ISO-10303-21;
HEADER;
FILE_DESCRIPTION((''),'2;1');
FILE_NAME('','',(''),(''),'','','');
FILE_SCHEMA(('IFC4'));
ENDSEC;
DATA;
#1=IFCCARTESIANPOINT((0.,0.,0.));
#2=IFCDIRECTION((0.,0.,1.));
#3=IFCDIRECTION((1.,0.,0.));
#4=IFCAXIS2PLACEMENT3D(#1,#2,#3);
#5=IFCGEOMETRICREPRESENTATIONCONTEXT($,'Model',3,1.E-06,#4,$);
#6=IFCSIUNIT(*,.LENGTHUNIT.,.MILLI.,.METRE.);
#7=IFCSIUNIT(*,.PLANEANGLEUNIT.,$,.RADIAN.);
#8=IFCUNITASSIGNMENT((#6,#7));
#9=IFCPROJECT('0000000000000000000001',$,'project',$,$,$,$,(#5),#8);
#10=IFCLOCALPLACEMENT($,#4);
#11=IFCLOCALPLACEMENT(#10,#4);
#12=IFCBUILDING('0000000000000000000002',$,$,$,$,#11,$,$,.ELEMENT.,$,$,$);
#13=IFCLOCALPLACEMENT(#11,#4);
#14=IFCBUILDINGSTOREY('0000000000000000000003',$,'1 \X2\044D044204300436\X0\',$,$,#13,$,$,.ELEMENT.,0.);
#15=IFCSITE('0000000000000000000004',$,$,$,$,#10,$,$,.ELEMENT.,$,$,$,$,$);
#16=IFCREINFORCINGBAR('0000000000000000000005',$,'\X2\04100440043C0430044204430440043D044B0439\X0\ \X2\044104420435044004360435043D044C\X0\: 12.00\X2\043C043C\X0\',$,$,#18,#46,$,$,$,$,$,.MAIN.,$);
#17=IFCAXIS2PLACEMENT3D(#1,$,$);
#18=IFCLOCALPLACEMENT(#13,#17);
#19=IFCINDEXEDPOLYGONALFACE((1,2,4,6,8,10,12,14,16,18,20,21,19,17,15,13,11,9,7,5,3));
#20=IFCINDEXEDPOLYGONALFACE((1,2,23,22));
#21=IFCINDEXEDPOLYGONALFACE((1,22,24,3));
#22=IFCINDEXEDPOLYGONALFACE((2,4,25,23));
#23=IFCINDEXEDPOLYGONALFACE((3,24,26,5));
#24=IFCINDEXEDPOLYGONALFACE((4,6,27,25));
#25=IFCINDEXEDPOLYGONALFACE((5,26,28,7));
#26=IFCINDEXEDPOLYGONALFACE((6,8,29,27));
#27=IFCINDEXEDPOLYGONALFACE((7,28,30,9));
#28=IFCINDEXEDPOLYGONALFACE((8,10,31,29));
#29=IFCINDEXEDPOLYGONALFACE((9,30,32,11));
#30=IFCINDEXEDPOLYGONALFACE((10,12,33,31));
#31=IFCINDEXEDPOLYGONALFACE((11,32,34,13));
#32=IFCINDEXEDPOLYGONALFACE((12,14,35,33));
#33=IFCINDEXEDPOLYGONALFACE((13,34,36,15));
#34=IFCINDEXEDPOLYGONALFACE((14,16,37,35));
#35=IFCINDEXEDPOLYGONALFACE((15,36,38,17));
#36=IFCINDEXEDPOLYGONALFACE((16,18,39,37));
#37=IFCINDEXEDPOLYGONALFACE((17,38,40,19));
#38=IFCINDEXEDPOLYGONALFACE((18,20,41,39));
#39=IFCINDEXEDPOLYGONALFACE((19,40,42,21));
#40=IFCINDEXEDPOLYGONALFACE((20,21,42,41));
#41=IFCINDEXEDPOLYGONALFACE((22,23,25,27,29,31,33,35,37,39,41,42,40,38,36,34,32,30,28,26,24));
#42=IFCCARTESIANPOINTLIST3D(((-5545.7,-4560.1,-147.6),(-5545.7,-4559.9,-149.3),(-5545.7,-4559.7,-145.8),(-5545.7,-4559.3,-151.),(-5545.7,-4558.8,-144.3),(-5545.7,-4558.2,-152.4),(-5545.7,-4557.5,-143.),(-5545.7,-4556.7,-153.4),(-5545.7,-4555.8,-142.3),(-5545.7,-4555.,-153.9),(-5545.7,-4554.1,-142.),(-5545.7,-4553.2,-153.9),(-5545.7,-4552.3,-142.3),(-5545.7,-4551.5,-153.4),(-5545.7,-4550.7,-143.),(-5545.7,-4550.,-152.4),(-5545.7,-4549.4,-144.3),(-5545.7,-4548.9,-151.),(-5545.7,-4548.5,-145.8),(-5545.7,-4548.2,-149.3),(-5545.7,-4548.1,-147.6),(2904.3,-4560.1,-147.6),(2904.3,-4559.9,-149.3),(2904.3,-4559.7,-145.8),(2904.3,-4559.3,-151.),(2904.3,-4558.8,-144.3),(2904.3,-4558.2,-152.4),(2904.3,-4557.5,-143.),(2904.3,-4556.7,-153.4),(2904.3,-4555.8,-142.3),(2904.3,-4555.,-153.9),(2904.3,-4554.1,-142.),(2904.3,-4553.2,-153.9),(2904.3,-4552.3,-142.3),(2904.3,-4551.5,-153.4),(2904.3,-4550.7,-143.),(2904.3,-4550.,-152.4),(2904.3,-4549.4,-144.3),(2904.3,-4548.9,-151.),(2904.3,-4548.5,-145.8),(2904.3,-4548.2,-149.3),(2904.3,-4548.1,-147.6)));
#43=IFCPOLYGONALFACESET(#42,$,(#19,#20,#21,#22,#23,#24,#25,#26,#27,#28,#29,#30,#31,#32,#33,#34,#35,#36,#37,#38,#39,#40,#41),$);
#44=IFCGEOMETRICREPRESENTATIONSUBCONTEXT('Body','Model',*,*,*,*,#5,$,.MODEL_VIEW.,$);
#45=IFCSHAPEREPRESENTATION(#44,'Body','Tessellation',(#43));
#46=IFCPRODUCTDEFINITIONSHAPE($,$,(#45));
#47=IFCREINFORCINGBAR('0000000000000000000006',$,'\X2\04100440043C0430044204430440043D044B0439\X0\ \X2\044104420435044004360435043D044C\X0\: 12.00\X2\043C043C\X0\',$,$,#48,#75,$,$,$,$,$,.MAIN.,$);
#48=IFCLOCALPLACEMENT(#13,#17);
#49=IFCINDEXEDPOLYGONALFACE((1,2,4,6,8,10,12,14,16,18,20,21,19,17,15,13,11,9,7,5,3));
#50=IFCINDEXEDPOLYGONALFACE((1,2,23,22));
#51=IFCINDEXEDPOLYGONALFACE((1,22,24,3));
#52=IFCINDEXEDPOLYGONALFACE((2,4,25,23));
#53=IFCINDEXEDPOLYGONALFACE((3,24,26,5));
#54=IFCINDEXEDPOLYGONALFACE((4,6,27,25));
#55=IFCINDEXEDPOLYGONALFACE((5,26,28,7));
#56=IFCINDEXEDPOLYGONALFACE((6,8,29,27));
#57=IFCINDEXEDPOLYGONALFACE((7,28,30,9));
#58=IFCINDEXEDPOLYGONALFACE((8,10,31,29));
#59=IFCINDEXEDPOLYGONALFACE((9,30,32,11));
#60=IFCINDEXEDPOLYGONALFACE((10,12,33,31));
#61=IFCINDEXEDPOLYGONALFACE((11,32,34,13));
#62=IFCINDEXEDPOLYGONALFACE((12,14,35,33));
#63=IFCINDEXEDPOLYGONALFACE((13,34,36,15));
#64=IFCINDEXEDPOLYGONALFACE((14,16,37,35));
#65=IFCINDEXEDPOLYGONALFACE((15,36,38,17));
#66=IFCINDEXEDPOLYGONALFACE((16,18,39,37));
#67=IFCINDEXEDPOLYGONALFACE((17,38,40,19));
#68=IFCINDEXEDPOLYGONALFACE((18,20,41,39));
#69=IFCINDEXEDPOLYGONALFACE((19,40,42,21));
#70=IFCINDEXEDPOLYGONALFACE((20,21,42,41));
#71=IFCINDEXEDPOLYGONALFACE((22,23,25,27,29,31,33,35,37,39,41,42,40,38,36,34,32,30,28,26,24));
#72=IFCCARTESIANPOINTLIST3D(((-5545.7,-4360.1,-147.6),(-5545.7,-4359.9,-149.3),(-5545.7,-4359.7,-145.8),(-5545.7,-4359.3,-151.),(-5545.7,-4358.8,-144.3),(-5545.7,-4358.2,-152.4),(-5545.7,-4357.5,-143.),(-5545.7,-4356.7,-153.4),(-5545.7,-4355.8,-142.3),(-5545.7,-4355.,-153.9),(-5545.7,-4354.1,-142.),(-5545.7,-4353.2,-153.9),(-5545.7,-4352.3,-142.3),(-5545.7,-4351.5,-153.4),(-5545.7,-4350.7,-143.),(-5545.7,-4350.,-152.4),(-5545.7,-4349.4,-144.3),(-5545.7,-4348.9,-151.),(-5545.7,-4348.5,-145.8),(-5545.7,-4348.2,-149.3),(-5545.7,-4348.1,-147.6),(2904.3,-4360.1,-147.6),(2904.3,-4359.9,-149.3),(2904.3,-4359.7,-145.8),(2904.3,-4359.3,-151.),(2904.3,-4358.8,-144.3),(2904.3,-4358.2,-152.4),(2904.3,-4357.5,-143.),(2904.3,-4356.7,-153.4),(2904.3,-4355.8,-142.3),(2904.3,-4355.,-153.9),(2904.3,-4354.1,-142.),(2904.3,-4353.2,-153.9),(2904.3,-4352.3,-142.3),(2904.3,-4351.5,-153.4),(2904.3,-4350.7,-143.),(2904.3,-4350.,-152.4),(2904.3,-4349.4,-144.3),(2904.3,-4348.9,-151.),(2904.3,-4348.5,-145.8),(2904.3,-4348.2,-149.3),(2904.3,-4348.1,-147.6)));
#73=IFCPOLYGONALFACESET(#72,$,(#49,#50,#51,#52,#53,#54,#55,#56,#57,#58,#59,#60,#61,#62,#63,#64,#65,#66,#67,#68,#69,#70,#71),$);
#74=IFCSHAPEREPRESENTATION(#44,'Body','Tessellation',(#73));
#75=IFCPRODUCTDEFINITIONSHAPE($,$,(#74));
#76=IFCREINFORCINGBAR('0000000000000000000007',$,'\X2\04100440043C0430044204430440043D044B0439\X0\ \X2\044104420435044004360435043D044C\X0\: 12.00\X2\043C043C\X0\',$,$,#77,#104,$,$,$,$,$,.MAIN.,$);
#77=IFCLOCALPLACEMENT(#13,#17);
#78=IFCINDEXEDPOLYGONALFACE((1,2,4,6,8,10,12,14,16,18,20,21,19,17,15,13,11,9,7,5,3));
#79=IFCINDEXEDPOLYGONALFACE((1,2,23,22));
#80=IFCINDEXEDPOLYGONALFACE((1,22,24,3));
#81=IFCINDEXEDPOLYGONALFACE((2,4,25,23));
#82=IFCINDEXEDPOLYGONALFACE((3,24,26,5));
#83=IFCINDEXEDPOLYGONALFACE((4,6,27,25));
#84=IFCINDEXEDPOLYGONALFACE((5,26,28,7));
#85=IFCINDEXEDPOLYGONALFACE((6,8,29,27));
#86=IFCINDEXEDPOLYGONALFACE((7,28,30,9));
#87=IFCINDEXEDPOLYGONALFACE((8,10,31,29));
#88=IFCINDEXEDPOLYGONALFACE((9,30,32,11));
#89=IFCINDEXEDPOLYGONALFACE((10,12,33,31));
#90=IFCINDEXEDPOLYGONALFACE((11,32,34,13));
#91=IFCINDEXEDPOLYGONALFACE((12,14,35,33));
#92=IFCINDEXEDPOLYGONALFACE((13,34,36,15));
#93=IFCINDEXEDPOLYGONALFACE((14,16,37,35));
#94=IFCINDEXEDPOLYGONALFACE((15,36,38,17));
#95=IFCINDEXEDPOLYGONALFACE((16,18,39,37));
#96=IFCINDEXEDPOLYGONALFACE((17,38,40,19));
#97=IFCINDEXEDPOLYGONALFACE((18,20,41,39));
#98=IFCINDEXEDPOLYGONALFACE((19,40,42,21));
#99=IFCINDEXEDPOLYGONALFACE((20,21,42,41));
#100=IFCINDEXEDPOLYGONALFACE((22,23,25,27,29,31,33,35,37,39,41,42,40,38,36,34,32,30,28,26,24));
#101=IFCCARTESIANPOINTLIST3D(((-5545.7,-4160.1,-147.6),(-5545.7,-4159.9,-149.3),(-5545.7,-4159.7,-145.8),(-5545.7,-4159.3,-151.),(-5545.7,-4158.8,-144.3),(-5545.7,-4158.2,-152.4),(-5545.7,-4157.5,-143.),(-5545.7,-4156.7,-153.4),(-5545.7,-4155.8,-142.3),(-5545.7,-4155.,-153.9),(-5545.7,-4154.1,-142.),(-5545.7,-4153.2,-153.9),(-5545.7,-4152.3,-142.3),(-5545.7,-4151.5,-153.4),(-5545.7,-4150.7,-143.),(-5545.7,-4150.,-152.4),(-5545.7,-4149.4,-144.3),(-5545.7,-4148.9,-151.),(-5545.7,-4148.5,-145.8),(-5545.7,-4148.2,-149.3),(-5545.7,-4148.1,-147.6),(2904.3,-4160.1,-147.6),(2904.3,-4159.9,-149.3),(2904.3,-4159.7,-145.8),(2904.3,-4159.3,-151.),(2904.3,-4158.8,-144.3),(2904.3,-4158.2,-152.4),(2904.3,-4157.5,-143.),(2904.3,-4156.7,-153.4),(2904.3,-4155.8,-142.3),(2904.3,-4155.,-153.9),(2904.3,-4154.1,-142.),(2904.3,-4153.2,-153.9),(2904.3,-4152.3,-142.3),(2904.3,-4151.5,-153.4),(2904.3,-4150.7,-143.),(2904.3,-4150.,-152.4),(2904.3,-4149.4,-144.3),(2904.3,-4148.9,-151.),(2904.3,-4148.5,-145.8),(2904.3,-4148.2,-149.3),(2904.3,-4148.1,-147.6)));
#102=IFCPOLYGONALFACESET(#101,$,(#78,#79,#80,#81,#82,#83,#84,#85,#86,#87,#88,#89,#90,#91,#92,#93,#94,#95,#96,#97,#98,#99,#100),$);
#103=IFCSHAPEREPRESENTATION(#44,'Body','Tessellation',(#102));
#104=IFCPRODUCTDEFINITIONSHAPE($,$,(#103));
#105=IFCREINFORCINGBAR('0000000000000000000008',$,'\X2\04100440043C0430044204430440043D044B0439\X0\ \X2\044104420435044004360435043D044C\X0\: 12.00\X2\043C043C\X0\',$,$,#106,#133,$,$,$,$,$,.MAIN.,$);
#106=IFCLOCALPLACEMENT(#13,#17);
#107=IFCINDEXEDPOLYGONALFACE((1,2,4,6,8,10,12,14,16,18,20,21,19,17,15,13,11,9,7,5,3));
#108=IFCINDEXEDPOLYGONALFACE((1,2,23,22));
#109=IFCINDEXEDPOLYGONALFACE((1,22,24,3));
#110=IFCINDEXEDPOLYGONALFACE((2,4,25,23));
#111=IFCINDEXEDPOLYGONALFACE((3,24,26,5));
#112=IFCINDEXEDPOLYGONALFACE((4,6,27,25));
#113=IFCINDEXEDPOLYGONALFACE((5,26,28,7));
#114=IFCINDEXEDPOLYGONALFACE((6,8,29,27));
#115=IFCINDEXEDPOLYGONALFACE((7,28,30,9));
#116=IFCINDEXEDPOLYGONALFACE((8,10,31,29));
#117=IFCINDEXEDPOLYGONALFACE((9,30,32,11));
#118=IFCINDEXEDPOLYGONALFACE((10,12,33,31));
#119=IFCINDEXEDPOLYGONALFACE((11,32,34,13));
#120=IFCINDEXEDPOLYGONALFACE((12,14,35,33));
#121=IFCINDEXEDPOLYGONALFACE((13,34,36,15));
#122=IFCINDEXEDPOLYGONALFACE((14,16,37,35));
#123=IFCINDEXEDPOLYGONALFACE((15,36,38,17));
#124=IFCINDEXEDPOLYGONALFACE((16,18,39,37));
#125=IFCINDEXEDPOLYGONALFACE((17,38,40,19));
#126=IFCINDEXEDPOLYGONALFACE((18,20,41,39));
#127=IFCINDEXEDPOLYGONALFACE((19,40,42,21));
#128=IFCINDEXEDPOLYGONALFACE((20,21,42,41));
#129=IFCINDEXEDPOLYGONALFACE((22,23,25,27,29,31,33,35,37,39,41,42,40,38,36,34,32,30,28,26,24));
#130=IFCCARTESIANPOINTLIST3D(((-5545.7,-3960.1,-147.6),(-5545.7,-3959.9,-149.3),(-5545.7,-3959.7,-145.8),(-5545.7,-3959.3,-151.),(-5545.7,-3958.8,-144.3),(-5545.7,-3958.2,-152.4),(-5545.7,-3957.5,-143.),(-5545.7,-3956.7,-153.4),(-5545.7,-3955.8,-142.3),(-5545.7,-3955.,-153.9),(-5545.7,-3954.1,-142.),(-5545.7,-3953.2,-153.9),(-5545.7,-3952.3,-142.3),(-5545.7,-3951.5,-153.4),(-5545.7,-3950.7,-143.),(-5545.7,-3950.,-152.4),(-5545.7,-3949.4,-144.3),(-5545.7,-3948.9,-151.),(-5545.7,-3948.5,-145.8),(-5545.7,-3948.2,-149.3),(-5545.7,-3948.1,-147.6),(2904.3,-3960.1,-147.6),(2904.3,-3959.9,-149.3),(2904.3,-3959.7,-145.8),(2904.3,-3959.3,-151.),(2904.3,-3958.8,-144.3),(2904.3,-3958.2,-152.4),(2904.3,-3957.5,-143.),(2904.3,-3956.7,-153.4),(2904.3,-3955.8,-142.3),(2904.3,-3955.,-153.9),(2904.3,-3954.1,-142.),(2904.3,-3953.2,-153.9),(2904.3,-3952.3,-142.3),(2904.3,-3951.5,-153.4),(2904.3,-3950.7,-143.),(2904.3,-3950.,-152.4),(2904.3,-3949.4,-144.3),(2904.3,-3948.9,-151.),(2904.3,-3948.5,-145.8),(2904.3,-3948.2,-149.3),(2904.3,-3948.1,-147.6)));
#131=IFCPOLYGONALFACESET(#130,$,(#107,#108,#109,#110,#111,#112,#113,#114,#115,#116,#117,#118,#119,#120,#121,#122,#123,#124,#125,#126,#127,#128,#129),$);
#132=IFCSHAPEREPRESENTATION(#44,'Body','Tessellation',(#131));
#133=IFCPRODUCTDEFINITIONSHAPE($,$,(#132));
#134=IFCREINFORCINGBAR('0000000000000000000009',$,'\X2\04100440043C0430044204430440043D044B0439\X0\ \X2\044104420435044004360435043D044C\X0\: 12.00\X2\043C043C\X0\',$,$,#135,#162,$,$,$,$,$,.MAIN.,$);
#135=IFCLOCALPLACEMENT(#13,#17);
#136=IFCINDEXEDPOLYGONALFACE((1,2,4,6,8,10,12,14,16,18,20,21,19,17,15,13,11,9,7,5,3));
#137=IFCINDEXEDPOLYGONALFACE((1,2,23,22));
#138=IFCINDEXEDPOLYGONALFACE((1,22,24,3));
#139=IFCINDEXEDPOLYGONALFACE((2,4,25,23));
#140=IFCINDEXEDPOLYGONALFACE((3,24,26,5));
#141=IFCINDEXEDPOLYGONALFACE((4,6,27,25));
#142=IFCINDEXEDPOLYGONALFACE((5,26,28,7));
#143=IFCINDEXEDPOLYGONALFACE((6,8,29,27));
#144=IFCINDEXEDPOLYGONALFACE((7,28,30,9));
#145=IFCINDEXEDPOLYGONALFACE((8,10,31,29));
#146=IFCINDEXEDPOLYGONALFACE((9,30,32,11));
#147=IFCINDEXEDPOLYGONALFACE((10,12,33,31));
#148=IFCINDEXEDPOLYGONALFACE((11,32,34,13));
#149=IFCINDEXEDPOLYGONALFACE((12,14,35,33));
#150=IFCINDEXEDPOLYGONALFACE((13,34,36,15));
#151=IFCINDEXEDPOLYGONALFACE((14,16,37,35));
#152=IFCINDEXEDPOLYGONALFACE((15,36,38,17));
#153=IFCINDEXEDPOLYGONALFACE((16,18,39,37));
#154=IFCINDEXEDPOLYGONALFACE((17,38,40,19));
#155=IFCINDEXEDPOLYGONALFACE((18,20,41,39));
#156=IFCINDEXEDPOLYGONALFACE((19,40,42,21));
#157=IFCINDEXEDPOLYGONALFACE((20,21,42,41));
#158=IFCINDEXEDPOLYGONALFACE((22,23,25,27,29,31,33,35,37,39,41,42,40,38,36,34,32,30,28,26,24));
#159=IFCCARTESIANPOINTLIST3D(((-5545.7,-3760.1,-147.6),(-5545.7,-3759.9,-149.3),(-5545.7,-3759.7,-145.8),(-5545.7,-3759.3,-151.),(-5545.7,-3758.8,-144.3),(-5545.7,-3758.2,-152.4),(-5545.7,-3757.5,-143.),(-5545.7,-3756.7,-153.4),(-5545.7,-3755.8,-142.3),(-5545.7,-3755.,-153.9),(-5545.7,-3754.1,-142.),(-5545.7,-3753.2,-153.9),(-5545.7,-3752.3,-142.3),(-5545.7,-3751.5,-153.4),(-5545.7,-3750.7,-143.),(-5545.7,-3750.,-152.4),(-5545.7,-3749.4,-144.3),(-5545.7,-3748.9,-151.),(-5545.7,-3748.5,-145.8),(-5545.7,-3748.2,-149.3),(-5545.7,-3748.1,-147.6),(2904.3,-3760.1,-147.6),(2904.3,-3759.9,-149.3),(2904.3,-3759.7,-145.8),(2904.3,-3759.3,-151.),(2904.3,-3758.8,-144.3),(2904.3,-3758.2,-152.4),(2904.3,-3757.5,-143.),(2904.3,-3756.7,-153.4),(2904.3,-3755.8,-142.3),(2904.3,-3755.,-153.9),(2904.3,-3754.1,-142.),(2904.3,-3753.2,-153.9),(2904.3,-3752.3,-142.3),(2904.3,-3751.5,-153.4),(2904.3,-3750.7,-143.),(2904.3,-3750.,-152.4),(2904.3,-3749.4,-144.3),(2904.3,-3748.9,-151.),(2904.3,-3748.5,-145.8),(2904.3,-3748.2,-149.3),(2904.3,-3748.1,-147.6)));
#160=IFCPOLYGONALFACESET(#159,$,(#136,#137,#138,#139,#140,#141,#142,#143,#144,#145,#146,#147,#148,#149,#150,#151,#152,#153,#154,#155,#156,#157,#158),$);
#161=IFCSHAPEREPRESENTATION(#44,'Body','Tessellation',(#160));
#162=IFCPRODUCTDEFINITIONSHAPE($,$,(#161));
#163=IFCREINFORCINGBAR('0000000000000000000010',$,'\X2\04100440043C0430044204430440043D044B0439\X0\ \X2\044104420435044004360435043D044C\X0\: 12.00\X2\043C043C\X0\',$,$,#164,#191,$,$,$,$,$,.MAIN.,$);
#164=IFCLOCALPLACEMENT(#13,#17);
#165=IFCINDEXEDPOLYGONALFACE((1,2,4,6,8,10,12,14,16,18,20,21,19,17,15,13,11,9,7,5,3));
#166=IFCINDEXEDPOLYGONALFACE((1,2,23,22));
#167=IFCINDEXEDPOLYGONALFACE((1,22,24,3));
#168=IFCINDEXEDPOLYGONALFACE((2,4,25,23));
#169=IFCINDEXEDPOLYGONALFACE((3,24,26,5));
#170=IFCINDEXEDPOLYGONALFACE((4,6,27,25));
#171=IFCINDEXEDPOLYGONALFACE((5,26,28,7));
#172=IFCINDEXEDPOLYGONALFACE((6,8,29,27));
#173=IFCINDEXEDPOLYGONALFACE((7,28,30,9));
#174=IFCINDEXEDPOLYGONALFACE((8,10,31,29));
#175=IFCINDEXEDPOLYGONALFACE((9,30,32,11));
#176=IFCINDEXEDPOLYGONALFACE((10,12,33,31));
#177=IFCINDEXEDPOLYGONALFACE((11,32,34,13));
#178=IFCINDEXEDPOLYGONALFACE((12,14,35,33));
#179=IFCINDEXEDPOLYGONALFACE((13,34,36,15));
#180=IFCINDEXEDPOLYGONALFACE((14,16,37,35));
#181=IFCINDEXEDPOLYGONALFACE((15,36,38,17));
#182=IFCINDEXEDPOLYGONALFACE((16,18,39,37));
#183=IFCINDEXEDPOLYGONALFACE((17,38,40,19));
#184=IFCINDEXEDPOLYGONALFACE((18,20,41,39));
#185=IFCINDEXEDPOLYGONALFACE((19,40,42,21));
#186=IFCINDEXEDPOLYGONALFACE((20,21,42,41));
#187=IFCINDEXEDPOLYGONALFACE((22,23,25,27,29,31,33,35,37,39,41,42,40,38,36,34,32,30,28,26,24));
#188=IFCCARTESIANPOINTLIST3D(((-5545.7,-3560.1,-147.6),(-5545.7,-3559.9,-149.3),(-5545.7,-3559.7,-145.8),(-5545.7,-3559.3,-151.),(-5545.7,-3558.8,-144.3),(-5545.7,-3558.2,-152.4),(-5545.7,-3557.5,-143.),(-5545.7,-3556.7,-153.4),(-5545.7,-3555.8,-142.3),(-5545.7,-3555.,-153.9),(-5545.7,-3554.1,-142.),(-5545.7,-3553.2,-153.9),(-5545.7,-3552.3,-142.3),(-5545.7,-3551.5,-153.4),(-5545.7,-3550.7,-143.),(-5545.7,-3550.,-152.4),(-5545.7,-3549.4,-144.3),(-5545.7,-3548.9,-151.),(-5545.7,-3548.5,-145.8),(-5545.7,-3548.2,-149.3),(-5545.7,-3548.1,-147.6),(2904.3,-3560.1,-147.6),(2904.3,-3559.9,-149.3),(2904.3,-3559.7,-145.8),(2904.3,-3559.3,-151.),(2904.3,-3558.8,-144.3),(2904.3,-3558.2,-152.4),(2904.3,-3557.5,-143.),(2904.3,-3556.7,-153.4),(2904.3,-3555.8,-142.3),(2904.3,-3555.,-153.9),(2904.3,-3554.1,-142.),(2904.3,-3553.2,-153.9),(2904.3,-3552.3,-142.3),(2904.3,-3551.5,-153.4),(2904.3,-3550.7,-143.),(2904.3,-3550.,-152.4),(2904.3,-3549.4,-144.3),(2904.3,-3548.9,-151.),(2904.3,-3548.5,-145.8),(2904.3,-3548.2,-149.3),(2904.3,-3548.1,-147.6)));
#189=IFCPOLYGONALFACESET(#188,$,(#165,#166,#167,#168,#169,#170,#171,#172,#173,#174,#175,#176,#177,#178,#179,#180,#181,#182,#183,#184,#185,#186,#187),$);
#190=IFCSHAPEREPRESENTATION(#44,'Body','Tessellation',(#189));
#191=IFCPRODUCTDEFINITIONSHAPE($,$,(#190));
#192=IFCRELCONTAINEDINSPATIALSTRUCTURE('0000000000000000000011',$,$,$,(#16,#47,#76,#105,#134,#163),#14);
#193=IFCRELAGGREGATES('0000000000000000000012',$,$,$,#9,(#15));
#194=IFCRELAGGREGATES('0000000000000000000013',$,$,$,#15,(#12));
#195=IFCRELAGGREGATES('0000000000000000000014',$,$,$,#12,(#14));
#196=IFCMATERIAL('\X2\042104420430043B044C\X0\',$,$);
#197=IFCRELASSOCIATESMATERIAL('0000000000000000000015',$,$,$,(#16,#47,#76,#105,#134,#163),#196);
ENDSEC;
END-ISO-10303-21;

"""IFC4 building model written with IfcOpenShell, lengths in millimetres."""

from ifc_helpers import new_model, entity, si_unit, origin_with_axes, place, context, subcontext, project, spatial, source, transform, mapped, material, element, save


model = new_model("IFC4")

# Units and contexts
model_context = context("Model", 3, precision=1e-06, world=origin_with_axes())
body_context = subcontext(model_context, "Body", "Model", "MODEL_VIEW")
ifc_project = project(units=[si_unit("LENGTHUNIT", "METRE", prefix="MILLI"), si_unit("PLANEANGLEUNIT", "RADIAN")], contexts=[model_context])

# Site, building, storey
site_placement = place(None, origin_with_axes())
site = spatial("IfcSite", under=ifc_project, at=site_placement, CompositionType="ELEMENT")
building_placement = place(site_placement, origin_with_axes())
building = spatial("IfcBuilding", under=site, at=building_placement, CompositionType="ELEMENT")
storey_placement = place(building_placement, origin_with_axes())
storey = spatial("IfcBuildingStorey", under=building, at=storey_placement, Name="1 этаж", CompositionType="ELEMENT", Elevation=0.0)

# Shared definitions
ifc_material_1 = material(Name="Сталь")

# Reinforcing bars
shared_shape_1 = source(origin_with_axes(), body_context, "Body", "AdvancedSweptSolid", [
    entity("IfcSweptDiskSolid", entity("IfcIndexedPolyCurve", entity("IfcCartesianPointList3D", [[0.0, 0.0, 0.0], [8450.0, 0.0, 0.0]]), [entity("IfcLineIndex", [1, 2])]), 6.0),
])
reinforcing_bar_1_placement = place(storey_placement, origin_with_axes())
element("IfcReinforcingBar", 1, at=reinforcing_bar_1_placement, inside=storey, material=ifc_material_1, Name="Арматурный стержень: 12.00мм", PredefinedType="MAIN", context=body_context, shape_type="MappedRepresentation", body=[
    mapped(shared_shape_1, transform((-5545.7, -4554.1, -148.0), x_axis=(1.0, 0.0, 0.0), y_axis=(0.0, 1.0, 0.0), z_axis=(0.0, 0.0, 1.0), scale=1.0)),
])
reinforcing_bar_2_placement = place(storey_placement, origin_with_axes())
element("IfcReinforcingBar", 2, at=reinforcing_bar_2_placement, inside=storey, material=ifc_material_1, Name="Арматурный стержень: 12.00мм", PredefinedType="MAIN", context=body_context, shape_type="MappedRepresentation", body=[
    mapped(shared_shape_1, transform((-5545.7, -4354.1, -148.0), x_axis=(1.0, 0.0, 0.0), y_axis=(0.0, 1.0, 0.0), z_axis=(0.0, 0.0, 1.0), scale=1.0)),
])
reinforcing_bar_3_placement = place(storey_placement, origin_with_axes())
element("IfcReinforcingBar", 3, at=reinforcing_bar_3_placement, inside=storey, material=ifc_material_1, Name="Арматурный стержень: 12.00мм", PredefinedType="MAIN", context=body_context, shape_type="MappedRepresentation", body=[
    mapped(shared_shape_1, transform((-5545.7, -4154.1, -148.0), x_axis=(1.0, 0.0, 0.0), y_axis=(0.0, 1.0, 0.0), z_axis=(0.0, 0.0, 1.0), scale=1.0)),
])
reinforcing_bar_4_placement = place(storey_placement, origin_with_axes())
element("IfcReinforcingBar", 4, at=reinforcing_bar_4_placement, inside=storey, material=ifc_material_1, Name="Арматурный стержень: 12.00мм", PredefinedType="MAIN", context=body_context, shape_type="MappedRepresentation", body=[
    mapped(shared_shape_1, transform((-5545.7, -3954.1, -148.0), x_axis=(1.0, 0.0, 0.0), y_axis=(0.0, 1.0, 0.0), z_axis=(0.0, 0.0, 1.0), scale=1.0)),
])
reinforcing_bar_5_placement = place(storey_placement, origin_with_axes())
element("IfcReinforcingBar", 5, at=reinforcing_bar_5_placement, inside=storey, material=ifc_material_1, Name="Арматурный стержень: 12.00мм", PredefinedType="MAIN", context=body_context, shape_type="MappedRepresentation", body=[
    mapped(shared_shape_1, transform((-5545.7, -3754.1, -148.0), x_axis=(1.0, 0.0, 0.0), y_axis=(0.0, 1.0, 0.0), z_axis=(0.0, 0.0, 1.0), scale=1.0)),
])
reinforcing_bar_6_placement = place(storey_placement, origin_with_axes())
element("IfcReinforcingBar", 6, at=reinforcing_bar_6_placement, inside=storey, material=ifc_material_1, Name="Арматурный стержень: 12.00мм", PredefinedType="MAIN", context=body_context, shape_type="MappedRepresentation", body=[
    mapped(shared_shape_1, transform((-5545.7, -3554.1, -148.0), x_axis=(1.0, 0.0, 0.0), y_axis=(0.0, 1.0, 0.0), z_axis=(0.0, 0.0, 1.0), scale=1.0)),
])

save(model, "model.ifc")
